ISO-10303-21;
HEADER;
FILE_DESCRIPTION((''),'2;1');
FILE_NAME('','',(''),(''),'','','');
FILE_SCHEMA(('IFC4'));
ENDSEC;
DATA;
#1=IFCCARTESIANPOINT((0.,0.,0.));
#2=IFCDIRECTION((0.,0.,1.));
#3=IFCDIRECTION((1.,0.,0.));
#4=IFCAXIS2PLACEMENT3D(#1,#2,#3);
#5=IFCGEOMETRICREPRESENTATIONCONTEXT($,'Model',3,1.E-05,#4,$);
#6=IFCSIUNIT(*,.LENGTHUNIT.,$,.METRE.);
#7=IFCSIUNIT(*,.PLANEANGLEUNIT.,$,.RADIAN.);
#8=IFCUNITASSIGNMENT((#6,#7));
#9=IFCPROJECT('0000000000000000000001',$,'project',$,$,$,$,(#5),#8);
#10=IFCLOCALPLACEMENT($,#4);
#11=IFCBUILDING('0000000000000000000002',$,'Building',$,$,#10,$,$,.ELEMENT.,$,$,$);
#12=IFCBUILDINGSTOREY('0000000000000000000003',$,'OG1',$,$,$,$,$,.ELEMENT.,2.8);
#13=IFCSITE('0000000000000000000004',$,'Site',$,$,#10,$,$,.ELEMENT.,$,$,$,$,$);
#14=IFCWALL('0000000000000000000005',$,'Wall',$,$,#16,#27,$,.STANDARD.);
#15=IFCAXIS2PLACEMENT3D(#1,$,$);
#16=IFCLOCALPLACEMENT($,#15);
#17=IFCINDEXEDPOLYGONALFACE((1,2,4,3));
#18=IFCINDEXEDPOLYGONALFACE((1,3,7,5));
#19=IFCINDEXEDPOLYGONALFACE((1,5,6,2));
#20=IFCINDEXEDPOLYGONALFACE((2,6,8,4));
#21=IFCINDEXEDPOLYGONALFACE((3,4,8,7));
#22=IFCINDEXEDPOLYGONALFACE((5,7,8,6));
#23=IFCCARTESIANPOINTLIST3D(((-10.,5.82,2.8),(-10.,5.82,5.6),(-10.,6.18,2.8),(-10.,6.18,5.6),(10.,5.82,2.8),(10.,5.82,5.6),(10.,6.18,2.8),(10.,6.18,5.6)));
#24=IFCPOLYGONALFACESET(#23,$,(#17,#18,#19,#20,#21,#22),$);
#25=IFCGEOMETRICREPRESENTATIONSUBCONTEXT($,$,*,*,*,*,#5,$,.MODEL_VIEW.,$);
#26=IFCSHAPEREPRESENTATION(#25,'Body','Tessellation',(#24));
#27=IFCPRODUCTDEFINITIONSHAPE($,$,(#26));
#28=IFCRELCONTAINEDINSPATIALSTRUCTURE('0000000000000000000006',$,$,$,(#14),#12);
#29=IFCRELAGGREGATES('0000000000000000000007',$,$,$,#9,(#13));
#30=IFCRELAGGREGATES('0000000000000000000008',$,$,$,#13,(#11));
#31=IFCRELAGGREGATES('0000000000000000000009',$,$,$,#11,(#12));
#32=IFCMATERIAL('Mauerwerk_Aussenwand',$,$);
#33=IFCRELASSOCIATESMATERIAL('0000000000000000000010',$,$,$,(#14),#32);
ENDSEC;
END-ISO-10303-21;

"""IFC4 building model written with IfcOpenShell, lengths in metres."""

from ifc_helpers import new_model, si_unit, frame, frame_2d, origin, origin_with_axes, place, context, subcontext, project, spatial, rectangle, extrude, material, element, save


model = new_model("IFC4")

# Units and contexts
model_context = context("Model", 3, precision=1e-05, world=origin_with_axes())
sub_context = subcontext(model_context, None, None, "MODEL_VIEW")
ifc_project = project(units=[si_unit("LENGTHUNIT", "METRE"), si_unit("PLANEANGLEUNIT", "RADIAN")], contexts=[model_context])

# Site, building, storey
placement_1 = place(None, origin_with_axes())
site = spatial("IfcSite", under=ifc_project, at=placement_1, Name="Site", CompositionType="ELEMENT")
building = spatial("IfcBuilding", under=site, at=placement_1, Name="Building", CompositionType="ELEMENT")
storey = spatial("IfcBuildingStorey", under=building, Name="OG1", CompositionType="ELEMENT", Elevation=2.8)

# Wall
ifc_material = material(Name="Mauerwerk_Aussenwand")
placement_2 = place(None, origin_with_axes())
placement_3 = place(placement_2, frame((0.0, 0.0, 2.8)))
wall_placement = place(placement_3, frame((-10.0, 6.0, 0.0), x_axis=(1.0, 0.0, 0.0)))
element("IfcWall", 1, at=wall_placement, inside=storey, material=ifc_material, Name="Wall", PredefinedType="STANDARD", context=sub_context, shape_type="SweptSolid", body=[
    extrude(rectangle(XDim=20.0, YDim=0.36, at=frame_2d((10.0, 0.0))), origin(), (0.0, 0.0, 1.0), 2.8),
])

save(model, "model.ifc")
